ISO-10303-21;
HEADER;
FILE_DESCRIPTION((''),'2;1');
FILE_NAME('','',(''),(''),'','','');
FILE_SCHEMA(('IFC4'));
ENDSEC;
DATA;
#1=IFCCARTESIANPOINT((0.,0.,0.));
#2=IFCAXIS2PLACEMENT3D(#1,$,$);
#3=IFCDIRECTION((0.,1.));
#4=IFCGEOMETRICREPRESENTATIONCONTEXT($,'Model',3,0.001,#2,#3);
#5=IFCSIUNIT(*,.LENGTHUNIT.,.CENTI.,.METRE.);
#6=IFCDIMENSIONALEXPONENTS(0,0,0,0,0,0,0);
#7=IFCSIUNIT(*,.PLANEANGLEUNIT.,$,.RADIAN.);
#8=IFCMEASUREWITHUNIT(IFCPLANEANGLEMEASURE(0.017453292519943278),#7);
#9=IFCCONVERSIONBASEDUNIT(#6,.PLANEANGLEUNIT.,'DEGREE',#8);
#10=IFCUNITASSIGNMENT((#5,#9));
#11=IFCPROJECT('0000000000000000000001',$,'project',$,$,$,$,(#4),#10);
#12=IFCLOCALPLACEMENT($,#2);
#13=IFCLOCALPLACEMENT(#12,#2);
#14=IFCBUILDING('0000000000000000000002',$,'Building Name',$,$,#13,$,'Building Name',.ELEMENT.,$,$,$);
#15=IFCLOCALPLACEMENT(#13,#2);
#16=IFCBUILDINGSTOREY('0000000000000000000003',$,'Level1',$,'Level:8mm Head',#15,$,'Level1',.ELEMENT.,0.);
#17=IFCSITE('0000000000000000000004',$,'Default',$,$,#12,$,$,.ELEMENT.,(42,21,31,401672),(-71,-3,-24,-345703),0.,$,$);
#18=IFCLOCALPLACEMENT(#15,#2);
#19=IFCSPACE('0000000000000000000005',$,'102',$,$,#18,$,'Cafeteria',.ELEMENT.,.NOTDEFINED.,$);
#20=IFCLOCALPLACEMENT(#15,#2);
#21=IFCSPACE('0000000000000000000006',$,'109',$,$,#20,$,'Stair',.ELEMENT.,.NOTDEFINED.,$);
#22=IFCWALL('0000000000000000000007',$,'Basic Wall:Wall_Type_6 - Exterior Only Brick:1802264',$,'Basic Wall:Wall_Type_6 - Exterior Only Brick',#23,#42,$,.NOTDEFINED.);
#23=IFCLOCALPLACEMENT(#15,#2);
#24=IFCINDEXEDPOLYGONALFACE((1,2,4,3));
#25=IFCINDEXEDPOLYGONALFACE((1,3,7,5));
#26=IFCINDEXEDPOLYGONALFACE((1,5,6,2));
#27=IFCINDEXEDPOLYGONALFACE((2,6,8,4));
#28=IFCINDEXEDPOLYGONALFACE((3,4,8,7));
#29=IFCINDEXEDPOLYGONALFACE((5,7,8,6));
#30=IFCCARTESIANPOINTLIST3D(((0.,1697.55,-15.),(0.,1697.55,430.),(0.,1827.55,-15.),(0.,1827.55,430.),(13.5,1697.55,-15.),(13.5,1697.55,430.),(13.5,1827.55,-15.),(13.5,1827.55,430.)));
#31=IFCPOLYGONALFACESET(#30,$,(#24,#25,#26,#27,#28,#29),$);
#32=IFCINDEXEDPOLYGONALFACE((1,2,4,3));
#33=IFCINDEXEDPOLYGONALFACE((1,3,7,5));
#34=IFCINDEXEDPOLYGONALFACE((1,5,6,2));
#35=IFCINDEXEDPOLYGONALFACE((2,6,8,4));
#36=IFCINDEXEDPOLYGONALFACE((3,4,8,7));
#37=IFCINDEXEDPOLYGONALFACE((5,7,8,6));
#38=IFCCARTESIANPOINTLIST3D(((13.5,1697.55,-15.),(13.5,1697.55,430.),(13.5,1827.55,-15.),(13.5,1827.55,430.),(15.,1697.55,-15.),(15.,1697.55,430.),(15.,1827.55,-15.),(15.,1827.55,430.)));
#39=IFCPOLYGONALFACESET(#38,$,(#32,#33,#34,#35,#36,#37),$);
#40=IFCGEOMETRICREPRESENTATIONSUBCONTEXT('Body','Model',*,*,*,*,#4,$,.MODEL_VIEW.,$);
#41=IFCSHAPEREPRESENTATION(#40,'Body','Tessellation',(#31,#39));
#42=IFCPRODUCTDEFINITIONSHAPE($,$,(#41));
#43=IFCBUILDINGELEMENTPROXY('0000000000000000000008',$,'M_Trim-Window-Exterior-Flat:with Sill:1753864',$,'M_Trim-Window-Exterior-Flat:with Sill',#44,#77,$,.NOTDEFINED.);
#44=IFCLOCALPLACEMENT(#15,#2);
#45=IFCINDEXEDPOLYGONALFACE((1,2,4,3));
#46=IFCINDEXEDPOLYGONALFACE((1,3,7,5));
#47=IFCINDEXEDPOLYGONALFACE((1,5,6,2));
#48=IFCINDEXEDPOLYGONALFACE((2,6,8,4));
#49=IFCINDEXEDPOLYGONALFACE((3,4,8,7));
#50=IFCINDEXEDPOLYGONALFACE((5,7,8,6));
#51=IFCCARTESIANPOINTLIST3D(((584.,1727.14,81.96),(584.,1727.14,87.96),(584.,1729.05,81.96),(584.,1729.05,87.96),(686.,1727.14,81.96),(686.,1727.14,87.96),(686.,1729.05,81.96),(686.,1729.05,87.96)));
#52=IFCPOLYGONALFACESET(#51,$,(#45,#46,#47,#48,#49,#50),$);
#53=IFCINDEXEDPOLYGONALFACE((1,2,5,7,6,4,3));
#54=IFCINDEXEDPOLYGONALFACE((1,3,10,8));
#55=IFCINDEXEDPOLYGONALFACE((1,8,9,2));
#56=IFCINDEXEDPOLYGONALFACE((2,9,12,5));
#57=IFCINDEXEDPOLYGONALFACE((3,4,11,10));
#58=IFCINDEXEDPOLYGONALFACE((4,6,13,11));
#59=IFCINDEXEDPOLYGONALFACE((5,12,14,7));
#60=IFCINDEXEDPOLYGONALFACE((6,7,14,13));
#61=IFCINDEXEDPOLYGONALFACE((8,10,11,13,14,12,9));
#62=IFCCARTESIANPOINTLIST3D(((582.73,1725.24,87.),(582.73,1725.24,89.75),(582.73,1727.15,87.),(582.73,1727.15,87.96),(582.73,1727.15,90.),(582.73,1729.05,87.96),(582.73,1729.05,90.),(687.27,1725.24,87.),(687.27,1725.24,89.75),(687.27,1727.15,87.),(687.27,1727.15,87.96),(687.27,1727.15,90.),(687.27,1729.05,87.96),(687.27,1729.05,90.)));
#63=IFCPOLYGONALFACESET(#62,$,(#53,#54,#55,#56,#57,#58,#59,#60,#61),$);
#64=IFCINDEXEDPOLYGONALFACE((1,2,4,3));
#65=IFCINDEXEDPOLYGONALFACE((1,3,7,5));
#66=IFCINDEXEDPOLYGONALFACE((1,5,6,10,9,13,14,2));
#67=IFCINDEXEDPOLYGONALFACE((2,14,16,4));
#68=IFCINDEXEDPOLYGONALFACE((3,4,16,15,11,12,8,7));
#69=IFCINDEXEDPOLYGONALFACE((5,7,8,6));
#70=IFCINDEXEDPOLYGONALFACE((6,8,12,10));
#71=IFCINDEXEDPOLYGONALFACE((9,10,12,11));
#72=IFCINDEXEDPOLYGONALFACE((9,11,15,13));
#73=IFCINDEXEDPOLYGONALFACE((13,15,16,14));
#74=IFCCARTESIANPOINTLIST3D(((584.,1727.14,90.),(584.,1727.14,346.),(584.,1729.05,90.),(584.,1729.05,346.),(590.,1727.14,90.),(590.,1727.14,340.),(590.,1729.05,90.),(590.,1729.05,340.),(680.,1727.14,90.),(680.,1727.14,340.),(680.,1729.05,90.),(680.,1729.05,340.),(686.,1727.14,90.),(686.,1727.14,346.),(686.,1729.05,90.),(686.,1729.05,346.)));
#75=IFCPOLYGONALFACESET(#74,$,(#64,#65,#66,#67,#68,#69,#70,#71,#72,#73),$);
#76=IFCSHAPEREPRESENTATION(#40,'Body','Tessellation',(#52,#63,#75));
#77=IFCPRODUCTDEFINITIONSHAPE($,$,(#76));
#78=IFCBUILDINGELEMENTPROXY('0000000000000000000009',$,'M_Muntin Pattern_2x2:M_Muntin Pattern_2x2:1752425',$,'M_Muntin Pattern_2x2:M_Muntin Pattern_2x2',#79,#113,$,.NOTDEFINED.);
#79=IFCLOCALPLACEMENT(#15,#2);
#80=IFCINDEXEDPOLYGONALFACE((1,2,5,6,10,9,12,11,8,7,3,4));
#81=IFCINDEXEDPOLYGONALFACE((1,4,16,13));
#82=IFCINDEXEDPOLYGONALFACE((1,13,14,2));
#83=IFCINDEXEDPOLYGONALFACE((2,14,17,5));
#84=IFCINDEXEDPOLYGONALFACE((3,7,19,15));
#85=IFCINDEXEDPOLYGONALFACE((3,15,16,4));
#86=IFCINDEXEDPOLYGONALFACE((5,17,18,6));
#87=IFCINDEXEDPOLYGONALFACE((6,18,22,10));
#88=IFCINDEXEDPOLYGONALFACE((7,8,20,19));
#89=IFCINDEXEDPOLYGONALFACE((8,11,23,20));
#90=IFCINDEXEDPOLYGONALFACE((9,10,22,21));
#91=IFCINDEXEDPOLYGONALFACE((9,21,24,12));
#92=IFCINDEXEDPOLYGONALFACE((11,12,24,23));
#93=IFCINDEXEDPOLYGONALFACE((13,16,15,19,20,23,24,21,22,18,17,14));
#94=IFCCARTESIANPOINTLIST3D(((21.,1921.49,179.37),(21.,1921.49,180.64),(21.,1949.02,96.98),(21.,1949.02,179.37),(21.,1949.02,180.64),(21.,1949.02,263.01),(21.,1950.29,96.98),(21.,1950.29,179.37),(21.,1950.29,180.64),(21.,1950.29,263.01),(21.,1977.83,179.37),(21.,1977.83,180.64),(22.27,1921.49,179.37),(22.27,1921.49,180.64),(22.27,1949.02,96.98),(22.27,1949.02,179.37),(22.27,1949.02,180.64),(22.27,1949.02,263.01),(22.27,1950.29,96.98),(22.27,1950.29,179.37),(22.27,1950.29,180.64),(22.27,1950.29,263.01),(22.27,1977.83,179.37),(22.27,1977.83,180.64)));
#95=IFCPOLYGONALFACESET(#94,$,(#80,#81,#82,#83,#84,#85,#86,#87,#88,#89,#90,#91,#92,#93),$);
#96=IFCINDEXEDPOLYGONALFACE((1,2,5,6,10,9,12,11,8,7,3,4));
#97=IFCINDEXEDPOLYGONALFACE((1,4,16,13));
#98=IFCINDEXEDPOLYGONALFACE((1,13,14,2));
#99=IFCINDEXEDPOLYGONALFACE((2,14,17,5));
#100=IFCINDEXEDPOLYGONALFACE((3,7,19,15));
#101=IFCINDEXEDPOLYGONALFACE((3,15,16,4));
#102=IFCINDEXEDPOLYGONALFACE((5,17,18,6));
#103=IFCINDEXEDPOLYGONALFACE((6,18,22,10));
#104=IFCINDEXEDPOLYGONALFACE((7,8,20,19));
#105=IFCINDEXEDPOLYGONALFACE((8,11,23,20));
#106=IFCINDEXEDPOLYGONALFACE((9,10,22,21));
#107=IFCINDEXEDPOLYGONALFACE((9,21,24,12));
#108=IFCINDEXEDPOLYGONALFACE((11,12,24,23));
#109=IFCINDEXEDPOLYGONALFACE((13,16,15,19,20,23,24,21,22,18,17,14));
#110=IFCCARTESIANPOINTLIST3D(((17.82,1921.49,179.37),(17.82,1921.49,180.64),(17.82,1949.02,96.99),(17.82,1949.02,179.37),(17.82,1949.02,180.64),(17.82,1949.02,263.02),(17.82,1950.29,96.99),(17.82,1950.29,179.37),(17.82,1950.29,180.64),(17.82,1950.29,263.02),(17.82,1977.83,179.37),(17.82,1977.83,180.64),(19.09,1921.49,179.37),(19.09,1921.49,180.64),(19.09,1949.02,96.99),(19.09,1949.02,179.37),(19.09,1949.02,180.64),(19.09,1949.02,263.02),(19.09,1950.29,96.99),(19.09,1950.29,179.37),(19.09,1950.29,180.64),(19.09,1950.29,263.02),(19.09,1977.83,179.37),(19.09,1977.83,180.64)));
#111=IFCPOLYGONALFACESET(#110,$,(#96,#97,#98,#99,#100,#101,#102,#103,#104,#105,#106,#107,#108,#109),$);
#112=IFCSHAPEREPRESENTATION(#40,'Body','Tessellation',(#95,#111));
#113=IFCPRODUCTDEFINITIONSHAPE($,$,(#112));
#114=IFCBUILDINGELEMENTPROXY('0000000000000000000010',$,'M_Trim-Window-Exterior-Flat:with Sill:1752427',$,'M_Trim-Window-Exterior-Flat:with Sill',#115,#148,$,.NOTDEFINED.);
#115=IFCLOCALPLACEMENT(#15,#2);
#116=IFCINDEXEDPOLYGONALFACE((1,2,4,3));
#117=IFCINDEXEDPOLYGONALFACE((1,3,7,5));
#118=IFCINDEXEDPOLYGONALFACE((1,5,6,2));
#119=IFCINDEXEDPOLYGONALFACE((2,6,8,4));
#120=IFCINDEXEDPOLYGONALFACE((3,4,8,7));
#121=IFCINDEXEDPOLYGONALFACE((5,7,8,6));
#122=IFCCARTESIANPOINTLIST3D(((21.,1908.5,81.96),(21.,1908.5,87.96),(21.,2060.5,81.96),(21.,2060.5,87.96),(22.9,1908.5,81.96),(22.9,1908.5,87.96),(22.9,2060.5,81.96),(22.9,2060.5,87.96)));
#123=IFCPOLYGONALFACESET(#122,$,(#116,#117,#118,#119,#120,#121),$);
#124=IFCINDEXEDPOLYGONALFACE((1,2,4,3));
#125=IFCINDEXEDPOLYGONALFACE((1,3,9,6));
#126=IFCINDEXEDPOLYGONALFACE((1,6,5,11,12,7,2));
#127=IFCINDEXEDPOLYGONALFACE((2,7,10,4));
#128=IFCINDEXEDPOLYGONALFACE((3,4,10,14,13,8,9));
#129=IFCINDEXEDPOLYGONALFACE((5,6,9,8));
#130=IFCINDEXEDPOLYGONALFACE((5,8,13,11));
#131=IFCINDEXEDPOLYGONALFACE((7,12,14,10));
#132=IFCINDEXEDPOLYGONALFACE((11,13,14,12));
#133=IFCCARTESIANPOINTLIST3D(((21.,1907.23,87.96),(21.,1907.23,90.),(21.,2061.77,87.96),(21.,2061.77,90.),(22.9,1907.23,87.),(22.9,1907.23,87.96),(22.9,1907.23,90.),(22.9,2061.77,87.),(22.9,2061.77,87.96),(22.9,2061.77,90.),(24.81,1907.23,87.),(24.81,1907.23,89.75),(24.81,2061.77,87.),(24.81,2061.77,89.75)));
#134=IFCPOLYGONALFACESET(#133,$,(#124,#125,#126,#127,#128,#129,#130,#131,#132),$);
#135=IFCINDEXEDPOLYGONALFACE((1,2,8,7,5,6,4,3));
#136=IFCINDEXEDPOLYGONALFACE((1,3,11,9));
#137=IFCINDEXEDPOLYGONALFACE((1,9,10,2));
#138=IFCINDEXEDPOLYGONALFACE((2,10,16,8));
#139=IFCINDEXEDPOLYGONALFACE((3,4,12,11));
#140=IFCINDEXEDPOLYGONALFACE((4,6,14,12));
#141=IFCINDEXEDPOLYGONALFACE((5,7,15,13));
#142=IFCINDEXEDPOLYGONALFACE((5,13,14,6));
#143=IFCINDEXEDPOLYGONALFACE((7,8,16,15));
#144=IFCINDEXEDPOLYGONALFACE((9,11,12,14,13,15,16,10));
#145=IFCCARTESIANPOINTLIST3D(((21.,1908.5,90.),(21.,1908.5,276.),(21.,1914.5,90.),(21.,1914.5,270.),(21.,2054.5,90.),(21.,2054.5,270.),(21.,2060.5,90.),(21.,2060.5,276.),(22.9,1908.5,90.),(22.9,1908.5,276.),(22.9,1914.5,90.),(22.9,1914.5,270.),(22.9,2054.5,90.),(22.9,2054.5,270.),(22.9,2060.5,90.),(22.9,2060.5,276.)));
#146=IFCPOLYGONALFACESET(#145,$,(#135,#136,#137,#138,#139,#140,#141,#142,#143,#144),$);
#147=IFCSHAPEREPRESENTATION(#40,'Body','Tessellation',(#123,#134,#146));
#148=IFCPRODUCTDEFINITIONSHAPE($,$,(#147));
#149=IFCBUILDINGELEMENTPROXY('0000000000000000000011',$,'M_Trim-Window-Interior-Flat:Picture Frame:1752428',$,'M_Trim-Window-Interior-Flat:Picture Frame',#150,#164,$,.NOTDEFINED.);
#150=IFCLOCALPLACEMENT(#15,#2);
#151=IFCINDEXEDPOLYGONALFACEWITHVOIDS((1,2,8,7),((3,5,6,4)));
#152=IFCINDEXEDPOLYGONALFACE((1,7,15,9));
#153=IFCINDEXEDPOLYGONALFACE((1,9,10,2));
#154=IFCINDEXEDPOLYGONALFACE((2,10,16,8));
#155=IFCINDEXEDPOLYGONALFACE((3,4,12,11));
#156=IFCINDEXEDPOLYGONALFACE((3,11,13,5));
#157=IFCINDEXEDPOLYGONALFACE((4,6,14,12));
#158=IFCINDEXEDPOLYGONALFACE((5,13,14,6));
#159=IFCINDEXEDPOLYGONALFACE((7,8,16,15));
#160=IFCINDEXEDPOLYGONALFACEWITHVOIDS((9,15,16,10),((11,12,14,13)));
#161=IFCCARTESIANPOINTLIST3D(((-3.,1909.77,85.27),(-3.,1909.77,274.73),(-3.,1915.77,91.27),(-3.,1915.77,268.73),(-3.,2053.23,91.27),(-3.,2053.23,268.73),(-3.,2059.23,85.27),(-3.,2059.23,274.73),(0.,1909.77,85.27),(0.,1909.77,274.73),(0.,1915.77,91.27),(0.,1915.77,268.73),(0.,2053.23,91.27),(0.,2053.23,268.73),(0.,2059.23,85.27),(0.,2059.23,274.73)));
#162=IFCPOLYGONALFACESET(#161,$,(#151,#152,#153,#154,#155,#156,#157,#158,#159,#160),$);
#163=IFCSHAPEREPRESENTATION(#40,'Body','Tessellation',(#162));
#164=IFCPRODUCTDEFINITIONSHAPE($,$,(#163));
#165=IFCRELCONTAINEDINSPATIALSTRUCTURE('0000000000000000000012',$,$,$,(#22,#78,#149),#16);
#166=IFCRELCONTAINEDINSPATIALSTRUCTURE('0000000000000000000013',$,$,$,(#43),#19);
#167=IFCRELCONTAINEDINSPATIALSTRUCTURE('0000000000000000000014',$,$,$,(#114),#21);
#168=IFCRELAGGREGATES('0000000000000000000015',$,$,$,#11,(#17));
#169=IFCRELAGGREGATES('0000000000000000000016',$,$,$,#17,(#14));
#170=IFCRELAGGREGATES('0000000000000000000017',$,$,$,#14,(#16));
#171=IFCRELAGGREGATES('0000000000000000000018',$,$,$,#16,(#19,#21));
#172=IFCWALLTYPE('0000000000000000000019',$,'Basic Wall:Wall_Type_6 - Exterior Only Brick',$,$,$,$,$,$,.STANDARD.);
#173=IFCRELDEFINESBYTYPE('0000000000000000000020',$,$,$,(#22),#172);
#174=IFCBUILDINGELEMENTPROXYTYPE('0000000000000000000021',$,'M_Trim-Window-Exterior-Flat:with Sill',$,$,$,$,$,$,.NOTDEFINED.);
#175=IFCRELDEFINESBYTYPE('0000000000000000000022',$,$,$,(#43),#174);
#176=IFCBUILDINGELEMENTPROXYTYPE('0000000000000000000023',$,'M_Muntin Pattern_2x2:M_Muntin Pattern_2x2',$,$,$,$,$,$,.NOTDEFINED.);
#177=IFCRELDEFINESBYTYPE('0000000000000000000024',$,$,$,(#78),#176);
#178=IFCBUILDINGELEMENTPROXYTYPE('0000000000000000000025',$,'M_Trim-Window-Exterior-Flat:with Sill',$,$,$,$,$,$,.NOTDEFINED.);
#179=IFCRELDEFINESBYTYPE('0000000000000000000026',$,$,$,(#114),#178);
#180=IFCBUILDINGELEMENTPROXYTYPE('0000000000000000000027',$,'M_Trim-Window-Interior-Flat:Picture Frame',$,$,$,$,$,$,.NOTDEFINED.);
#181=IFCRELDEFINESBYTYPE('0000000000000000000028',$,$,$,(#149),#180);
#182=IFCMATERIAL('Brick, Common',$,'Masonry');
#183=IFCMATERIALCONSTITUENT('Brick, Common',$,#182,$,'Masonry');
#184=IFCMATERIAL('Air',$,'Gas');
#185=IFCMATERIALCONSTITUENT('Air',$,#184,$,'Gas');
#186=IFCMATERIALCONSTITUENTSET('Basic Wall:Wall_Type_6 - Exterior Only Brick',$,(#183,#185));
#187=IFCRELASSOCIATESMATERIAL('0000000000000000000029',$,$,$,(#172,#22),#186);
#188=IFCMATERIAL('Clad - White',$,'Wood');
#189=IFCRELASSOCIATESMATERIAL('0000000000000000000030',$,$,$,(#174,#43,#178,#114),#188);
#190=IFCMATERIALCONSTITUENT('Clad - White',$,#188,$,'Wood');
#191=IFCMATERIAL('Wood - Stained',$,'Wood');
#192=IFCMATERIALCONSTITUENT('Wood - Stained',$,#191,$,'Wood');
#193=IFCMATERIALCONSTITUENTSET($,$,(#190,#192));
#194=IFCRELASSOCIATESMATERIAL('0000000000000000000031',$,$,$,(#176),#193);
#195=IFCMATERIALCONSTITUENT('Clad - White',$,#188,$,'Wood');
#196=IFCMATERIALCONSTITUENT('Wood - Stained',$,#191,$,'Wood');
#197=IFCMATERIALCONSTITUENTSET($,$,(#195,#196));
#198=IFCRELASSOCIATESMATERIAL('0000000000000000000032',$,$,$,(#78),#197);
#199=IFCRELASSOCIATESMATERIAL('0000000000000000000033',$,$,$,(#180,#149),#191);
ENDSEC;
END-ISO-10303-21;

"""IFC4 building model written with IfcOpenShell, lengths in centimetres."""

from ifc_helpers import new_model, entity, si_unit, converted_unit, direction, frame, origin, place, context, subcontext, project, spatial, indexed_curve, outline, extrude, source, transform, mapped, material, constituent, constituent_set, type_object, type_shapes, element, save


model = new_model("IFC4")

# Units and contexts
model_context = context("Model", 3, precision=0.001, world=origin(), true_north=direction((0.0, 1.0)))
body_context = subcontext(model_context, "Body", "Model", "MODEL_VIEW")
ifc_project = project(units=[si_unit("LENGTHUNIT", "METRE", prefix="CENTI"), converted_unit("PLANEANGLEUNIT", "DEGREE", entity("IfcPlaneAngleMeasure", 0.017453292519943278), si_unit("PLANEANGLEUNIT", "RADIAN"), dimensions=[0, 0, 0, 0, 0, 0, 0])], contexts=[model_context])

# Site, building, storey
site_placement = place(None, origin())
site = spatial("IfcSite", under=ifc_project, at=site_placement, Name="Default", CompositionType="ELEMENT", RefLatitude=(42, 21, 31, 401672), RefLongitude=(-71, -3, -24, -345703), RefElevation=0.0)
building_placement = place(site_placement, origin())
building = spatial("IfcBuilding", under=site, at=building_placement, Name="Building Name", LongName="Building Name", CompositionType="ELEMENT")
storey_placement = place(building_placement, origin())
storey = spatial("IfcBuildingStorey", under=building, at=storey_placement, Name="Level1", ObjectType="Level:8mm Head", LongName="Level1", CompositionType="ELEMENT", Elevation=0.0)

# Shared definitions
ifc_material_1 = material(Name="Brick, Common", Category="Masonry")
ifc_material_2 = material(Name="Air", Category="Gas")

# Shared definitions
ifc_constituent_1 = constituent(ifc_material_1, Name="Brick, Common", Category="Masonry")
ifc_constituent_2 = constituent(ifc_material_2, Name="Air", Category="Gas")
ifc_constituent_set_1 = constituent_set(constituents=[ifc_constituent_1, ifc_constituent_2], Name="Basic Wall:Wall_Type_6 - Exterior Only Brick")
wall_type_1 = type_object("IfcWallType", Name="Basic Wall:Wall_Type_6 - Exterior Only Brick", PredefinedType="STANDARD", material=ifc_constituent_set_1)

# Wall
wall_1_placement = place(storey_placement, frame((7.5, 1697.55, -15.0), z_axis=(0.0, 0.0, 1.0), x_axis=(0.0, 1.0, 0.0)))
element("IfcWall", 1, at=wall_1_placement, inside=storey, type_object=wall_type_1, material=ifc_constituent_set_1, Name="Basic Wall:Wall_Type_6 - Exterior Only Brick:1802264", ObjectType="Basic Wall:Wall_Type_6 - Exterior Only Brick", PredefinedType="NOTDEFINED", context=body_context, shape_type="SweptSolid", body=[
    extrude(outline(indexed_curve([(-6.75, -65.0), (6.75, -65.0), (6.75, 65.0), (-6.75, 65.0), (-6.75, -65.0)], self_intersect=False)), frame((65.0, 0.75, 0.0), z_axis=(0.0, 0.0, 1.0), x_axis=(0.0, -1.0, 0.0)), (0.0, 0.0, 1.0), 445.0),
    extrude(outline(indexed_curve([(-0.75, -65.0), (0.75, -65.0), (0.75, 65.0), (-0.75, 65.0), (-0.75, -65.0)], self_intersect=False)), frame((65.0, -6.75, 0.0), z_axis=(0.0, 0.0, 1.0), x_axis=(0.0, 1.0, 0.0)), (0.0, 0.0, 1.0), 445.0),
])

# Shared definitions
space_1_placement = place(storey_placement, origin())
space_1 = spatial("IfcSpace", under=storey, at=space_1_placement, Name="102", LongName="Cafeteria", CompositionType="ELEMENT", PredefinedType="NOTDEFINED")

# Building element proxies
ifc_material_3 = material(Name="Clad - White", Category="Wood")
building_element_proxy_type_1 = type_object("IfcBuildingElementProxyType", Name="M_Trim-Window-Exterior-Flat:with Sill", PredefinedType="NOTDEFINED", material=ifc_material_3)
shared_shape_1 = source(origin(), body_context, "Body", "SweptSolid", [
    extrude(outline(indexed_curve([(-3.0, -51.0), (3.0, -51.0), (3.0, 51.0), (-3.0, 51.0), (-3.0, -51.0)], self_intersect=False)), frame((0.0, 255.04, 0.0), z_axis=(0.0, 0.0, 1.0), x_axis=(0.0, 1.0, 0.0)), (0.0, 0.0, 1.0), 1.9),
    extrude(outline(indexed_curve([(-1.52, -1.9), (1.23, -1.9), (1.48, 0.0), (1.48, 1.9), (-0.57, 1.9), (-0.57, 0.0), (-1.52, 0.0), (-1.52, -1.9)], self_intersect=False)), frame((-52.27, 251.48, 1.9), z_axis=(1.0, 0.0, 0.0), x_axis=(0.0, -1.0, 0.0)), (0.0, 0.0, 1.0), 104.54),
    extrude(outline(indexed_curve([(-51.0, -129.5), (51.0, -129.5), (51.0, 126.5), (45.0, 126.5), (45.0, -123.5), (-45.0, -123.5), (-45.0, 126.5), (-51.0, 126.5), (-51.0, -129.5)], self_intersect=False)), frame((0.0, 123.5, 0.0)), (0.0, 0.0, 1.0), 1.9),
])
type_shapes(building_element_proxy_type_1, [shared_shape_1])
proxy_1_placement = place(space_1_placement, frame((635.0, 1729.05, 340.0), z_axis=(0.0, -1.0, 0.0), x_axis=(-1.0, 0.0, 0.0)))
element("IfcBuildingElementProxy", 2, at=proxy_1_placement, inside=space_1, type_object=building_element_proxy_type_1, material=ifc_material_3, Name="M_Trim-Window-Exterior-Flat:with Sill:1753864", ObjectType="M_Trim-Window-Exterior-Flat:with Sill", PredefinedType="NOTDEFINED", context=body_context, shape_type="MappedRepresentation", body=[
    mapped(shared_shape_1, transform((0.0, 0.0, 0.0), scale=1.0)),
])
ifc_constituent_3 = constituent(ifc_material_3, Name="Clad - White", Category="Wood")
ifc_material_4 = material(Name="Wood - Stained", Category="Wood")
ifc_constituent_4 = constituent(ifc_material_4, Name="Wood - Stained", Category="Wood")
ifc_constituent_set_2 = constituent_set(constituents=[ifc_constituent_3, ifc_constituent_4])
ifc_constituent_5 = constituent(ifc_material_3, Name="Clad - White", Category="Wood")
ifc_constituent_6 = constituent(ifc_material_4, Name="Wood - Stained", Category="Wood")
ifc_constituent_set_3 = constituent_set(constituents=[ifc_constituent_5, ifc_constituent_6])
building_element_proxy_type_2 = type_object("IfcBuildingElementProxyType", Name="M_Muntin Pattern_2x2:M_Muntin Pattern_2x2", PredefinedType="NOTDEFINED", material=ifc_constituent_set_3)
shared_shape_2 = source(origin(), body_context, "Body", "SweptSolid", [
    extrude(outline(indexed_curve([(0.64, -0.64), (83.01, -0.64), (83.01, 0.63), (0.64, 0.63), (0.64, 28.17), (-0.63, 28.17), (-0.63, 0.63), (-83.02, 0.63), (-83.02, -0.64), (-0.63, -0.64), (-0.63, -28.17), (0.64, -28.17), (0.64, -0.64)], self_intersect=False)), frame((0.0, -2.22, 83.01), z_axis=(0.0, 1.0, 0.0), x_axis=(0.0, 0.0, 1.0)), (0.0, 0.0, 1.0), 1.27),
    extrude(outline(indexed_curve([(0.64, -0.64), (83.02, -0.64), (83.02, 0.63), (0.64, 0.63), (0.64, 28.17), (-0.63, 28.17), (-0.63, 0.63), (-83.02, 0.63), (-83.02, -0.64), (-0.63, -0.64), (-0.63, -28.17), (0.64, -28.17), (0.64, -0.64)], self_intersect=False)), frame((0.0, 0.95, 83.02), z_axis=(0.0, 1.0, 0.0), x_axis=(0.0, 0.0, 1.0)), (0.0, 0.0, 1.0), 1.27),
])
type_shapes(building_element_proxy_type_2, [shared_shape_2])
proxy_2_placement = place(storey_placement, frame((20.05, 1949.66, 96.99), z_axis=(0.0, 0.0, 1.0), x_axis=(0.0, 1.0, 0.0)))
element("IfcBuildingElementProxy", 3, at=proxy_2_placement, inside=storey, type_object=building_element_proxy_type_2, material=ifc_constituent_set_2, Name="M_Muntin Pattern_2x2:M_Muntin Pattern_2x2:1752425", ObjectType="M_Muntin Pattern_2x2:M_Muntin Pattern_2x2", PredefinedType="NOTDEFINED", context=body_context, shape_type="MappedRepresentation", body=[
    mapped(shared_shape_2, transform((0.0, 0.0, 0.0), scale=1.0)),
])

# Shared definitions
space_2_placement = place(storey_placement, origin())
space_2 = spatial("IfcSpace", under=storey, at=space_2_placement, Name="109", LongName="Stair", CompositionType="ELEMENT", PredefinedType="NOTDEFINED")

# Building element proxies
building_element_proxy_type_3 = type_object("IfcBuildingElementProxyType", Name="M_Trim-Window-Exterior-Flat:with Sill", PredefinedType="NOTDEFINED", material=ifc_material_3)
shared_shape_3 = source(origin(), body_context, "Body", "SweptSolid", [
    extrude(outline(indexed_curve([(-76.0, -3.0), (76.0, -3.0), (76.0, 3.0), (-76.0, 3.0), (-76.0, -3.0)], self_intersect=False)), frame((0.0, -185.04, 0.0), z_axis=(0.0, 0.0, 1.0), x_axis=(-1.0, 0.0, 0.0)), (0.0, 0.0, 1.0), 1.9),
    extrude(outline(indexed_curve([(-1.9, -1.52), (0.0, -1.52), (0.0, -0.57), (1.9, -0.57), (1.9, 1.48), (0.0, 1.48), (-1.9, 1.23), (-1.9, -1.52)], self_intersect=False)), frame((-77.27, -181.48, 1.9), z_axis=(1.0, 0.0, 0.0), x_axis=(0.0, 0.0, -1.0)), (0.0, 0.0, 1.0), 154.54),
    extrude(outline(indexed_curve([(-94.5, -76.0), (91.5, -76.0), (91.5, -70.0), (-88.5, -70.0), (-88.5, 70.0), (91.5, 70.0), (91.5, 76.0), (-94.5, 76.0), (-94.5, -76.0)], self_intersect=False)), frame((0.0, -88.5, 0.0), z_axis=(0.0, 0.0, 1.0), x_axis=(0.0, -1.0, 0.0)), (0.0, 0.0, 1.0), 1.9),
])
type_shapes(building_element_proxy_type_3, [shared_shape_3])
proxy_3_placement = place(space_2_placement, frame((21.0, 1984.5, 270.0), z_axis=(1.0, 0.0, 0.0), x_axis=(0.0, 1.0, 0.0)))
element("IfcBuildingElementProxy", 4, at=proxy_3_placement, inside=space_2, type_object=building_element_proxy_type_3, material=ifc_material_3, Name="M_Trim-Window-Exterior-Flat:with Sill:1752427", ObjectType="M_Trim-Window-Exterior-Flat:with Sill", PredefinedType="NOTDEFINED", context=body_context, shape_type="MappedRepresentation", body=[
    mapped(shared_shape_3, transform((0.0, 0.0, 0.0), scale=1.0)),
])
building_element_proxy_type_4 = type_object("IfcBuildingElementProxyType", Name="M_Trim-Window-Interior-Flat:Picture Frame", PredefinedType="NOTDEFINED", material=ifc_material_4)
shared_shape_4 = source(origin(), body_context, "Body", "SweptSolid", [
    extrude(outline(indexed_curve([(-74.73, -94.73), (74.73, -94.73), (74.73, 94.73), (-74.73, 94.73), (-74.73, -94.73)], self_intersect=False), holes=[indexed_curve([(-68.73, -88.73), (-68.73, 88.73), (68.73, 88.73), (68.73, -88.73), (-68.73, -88.73)], self_intersect=False)]), frame((0.0, -90.0, 0.0), z_axis=(0.0, 0.0, 1.0), x_axis=(-1.0, 0.0, 0.0)), (0.0, 0.0, 1.0), 3.0),
])
type_shapes(building_element_proxy_type_4, [shared_shape_4])
proxy_4_placement = place(storey_placement, frame((0.0, 1984.5, 270.0), z_axis=(-1.0, 0.0, 0.0), x_axis=(0.0, -1.0, 0.0)))
element("IfcBuildingElementProxy", 5, at=proxy_4_placement, inside=storey, type_object=building_element_proxy_type_4, material=ifc_material_4, Name="M_Trim-Window-Interior-Flat:Picture Frame:1752428", ObjectType="M_Trim-Window-Interior-Flat:Picture Frame", PredefinedType="NOTDEFINED", context=body_context, shape_type="MappedRepresentation", body=[
    mapped(shared_shape_4, transform((0.0, 0.0, 0.0), scale=1.0)),
])

save(model, "model.ifc")
